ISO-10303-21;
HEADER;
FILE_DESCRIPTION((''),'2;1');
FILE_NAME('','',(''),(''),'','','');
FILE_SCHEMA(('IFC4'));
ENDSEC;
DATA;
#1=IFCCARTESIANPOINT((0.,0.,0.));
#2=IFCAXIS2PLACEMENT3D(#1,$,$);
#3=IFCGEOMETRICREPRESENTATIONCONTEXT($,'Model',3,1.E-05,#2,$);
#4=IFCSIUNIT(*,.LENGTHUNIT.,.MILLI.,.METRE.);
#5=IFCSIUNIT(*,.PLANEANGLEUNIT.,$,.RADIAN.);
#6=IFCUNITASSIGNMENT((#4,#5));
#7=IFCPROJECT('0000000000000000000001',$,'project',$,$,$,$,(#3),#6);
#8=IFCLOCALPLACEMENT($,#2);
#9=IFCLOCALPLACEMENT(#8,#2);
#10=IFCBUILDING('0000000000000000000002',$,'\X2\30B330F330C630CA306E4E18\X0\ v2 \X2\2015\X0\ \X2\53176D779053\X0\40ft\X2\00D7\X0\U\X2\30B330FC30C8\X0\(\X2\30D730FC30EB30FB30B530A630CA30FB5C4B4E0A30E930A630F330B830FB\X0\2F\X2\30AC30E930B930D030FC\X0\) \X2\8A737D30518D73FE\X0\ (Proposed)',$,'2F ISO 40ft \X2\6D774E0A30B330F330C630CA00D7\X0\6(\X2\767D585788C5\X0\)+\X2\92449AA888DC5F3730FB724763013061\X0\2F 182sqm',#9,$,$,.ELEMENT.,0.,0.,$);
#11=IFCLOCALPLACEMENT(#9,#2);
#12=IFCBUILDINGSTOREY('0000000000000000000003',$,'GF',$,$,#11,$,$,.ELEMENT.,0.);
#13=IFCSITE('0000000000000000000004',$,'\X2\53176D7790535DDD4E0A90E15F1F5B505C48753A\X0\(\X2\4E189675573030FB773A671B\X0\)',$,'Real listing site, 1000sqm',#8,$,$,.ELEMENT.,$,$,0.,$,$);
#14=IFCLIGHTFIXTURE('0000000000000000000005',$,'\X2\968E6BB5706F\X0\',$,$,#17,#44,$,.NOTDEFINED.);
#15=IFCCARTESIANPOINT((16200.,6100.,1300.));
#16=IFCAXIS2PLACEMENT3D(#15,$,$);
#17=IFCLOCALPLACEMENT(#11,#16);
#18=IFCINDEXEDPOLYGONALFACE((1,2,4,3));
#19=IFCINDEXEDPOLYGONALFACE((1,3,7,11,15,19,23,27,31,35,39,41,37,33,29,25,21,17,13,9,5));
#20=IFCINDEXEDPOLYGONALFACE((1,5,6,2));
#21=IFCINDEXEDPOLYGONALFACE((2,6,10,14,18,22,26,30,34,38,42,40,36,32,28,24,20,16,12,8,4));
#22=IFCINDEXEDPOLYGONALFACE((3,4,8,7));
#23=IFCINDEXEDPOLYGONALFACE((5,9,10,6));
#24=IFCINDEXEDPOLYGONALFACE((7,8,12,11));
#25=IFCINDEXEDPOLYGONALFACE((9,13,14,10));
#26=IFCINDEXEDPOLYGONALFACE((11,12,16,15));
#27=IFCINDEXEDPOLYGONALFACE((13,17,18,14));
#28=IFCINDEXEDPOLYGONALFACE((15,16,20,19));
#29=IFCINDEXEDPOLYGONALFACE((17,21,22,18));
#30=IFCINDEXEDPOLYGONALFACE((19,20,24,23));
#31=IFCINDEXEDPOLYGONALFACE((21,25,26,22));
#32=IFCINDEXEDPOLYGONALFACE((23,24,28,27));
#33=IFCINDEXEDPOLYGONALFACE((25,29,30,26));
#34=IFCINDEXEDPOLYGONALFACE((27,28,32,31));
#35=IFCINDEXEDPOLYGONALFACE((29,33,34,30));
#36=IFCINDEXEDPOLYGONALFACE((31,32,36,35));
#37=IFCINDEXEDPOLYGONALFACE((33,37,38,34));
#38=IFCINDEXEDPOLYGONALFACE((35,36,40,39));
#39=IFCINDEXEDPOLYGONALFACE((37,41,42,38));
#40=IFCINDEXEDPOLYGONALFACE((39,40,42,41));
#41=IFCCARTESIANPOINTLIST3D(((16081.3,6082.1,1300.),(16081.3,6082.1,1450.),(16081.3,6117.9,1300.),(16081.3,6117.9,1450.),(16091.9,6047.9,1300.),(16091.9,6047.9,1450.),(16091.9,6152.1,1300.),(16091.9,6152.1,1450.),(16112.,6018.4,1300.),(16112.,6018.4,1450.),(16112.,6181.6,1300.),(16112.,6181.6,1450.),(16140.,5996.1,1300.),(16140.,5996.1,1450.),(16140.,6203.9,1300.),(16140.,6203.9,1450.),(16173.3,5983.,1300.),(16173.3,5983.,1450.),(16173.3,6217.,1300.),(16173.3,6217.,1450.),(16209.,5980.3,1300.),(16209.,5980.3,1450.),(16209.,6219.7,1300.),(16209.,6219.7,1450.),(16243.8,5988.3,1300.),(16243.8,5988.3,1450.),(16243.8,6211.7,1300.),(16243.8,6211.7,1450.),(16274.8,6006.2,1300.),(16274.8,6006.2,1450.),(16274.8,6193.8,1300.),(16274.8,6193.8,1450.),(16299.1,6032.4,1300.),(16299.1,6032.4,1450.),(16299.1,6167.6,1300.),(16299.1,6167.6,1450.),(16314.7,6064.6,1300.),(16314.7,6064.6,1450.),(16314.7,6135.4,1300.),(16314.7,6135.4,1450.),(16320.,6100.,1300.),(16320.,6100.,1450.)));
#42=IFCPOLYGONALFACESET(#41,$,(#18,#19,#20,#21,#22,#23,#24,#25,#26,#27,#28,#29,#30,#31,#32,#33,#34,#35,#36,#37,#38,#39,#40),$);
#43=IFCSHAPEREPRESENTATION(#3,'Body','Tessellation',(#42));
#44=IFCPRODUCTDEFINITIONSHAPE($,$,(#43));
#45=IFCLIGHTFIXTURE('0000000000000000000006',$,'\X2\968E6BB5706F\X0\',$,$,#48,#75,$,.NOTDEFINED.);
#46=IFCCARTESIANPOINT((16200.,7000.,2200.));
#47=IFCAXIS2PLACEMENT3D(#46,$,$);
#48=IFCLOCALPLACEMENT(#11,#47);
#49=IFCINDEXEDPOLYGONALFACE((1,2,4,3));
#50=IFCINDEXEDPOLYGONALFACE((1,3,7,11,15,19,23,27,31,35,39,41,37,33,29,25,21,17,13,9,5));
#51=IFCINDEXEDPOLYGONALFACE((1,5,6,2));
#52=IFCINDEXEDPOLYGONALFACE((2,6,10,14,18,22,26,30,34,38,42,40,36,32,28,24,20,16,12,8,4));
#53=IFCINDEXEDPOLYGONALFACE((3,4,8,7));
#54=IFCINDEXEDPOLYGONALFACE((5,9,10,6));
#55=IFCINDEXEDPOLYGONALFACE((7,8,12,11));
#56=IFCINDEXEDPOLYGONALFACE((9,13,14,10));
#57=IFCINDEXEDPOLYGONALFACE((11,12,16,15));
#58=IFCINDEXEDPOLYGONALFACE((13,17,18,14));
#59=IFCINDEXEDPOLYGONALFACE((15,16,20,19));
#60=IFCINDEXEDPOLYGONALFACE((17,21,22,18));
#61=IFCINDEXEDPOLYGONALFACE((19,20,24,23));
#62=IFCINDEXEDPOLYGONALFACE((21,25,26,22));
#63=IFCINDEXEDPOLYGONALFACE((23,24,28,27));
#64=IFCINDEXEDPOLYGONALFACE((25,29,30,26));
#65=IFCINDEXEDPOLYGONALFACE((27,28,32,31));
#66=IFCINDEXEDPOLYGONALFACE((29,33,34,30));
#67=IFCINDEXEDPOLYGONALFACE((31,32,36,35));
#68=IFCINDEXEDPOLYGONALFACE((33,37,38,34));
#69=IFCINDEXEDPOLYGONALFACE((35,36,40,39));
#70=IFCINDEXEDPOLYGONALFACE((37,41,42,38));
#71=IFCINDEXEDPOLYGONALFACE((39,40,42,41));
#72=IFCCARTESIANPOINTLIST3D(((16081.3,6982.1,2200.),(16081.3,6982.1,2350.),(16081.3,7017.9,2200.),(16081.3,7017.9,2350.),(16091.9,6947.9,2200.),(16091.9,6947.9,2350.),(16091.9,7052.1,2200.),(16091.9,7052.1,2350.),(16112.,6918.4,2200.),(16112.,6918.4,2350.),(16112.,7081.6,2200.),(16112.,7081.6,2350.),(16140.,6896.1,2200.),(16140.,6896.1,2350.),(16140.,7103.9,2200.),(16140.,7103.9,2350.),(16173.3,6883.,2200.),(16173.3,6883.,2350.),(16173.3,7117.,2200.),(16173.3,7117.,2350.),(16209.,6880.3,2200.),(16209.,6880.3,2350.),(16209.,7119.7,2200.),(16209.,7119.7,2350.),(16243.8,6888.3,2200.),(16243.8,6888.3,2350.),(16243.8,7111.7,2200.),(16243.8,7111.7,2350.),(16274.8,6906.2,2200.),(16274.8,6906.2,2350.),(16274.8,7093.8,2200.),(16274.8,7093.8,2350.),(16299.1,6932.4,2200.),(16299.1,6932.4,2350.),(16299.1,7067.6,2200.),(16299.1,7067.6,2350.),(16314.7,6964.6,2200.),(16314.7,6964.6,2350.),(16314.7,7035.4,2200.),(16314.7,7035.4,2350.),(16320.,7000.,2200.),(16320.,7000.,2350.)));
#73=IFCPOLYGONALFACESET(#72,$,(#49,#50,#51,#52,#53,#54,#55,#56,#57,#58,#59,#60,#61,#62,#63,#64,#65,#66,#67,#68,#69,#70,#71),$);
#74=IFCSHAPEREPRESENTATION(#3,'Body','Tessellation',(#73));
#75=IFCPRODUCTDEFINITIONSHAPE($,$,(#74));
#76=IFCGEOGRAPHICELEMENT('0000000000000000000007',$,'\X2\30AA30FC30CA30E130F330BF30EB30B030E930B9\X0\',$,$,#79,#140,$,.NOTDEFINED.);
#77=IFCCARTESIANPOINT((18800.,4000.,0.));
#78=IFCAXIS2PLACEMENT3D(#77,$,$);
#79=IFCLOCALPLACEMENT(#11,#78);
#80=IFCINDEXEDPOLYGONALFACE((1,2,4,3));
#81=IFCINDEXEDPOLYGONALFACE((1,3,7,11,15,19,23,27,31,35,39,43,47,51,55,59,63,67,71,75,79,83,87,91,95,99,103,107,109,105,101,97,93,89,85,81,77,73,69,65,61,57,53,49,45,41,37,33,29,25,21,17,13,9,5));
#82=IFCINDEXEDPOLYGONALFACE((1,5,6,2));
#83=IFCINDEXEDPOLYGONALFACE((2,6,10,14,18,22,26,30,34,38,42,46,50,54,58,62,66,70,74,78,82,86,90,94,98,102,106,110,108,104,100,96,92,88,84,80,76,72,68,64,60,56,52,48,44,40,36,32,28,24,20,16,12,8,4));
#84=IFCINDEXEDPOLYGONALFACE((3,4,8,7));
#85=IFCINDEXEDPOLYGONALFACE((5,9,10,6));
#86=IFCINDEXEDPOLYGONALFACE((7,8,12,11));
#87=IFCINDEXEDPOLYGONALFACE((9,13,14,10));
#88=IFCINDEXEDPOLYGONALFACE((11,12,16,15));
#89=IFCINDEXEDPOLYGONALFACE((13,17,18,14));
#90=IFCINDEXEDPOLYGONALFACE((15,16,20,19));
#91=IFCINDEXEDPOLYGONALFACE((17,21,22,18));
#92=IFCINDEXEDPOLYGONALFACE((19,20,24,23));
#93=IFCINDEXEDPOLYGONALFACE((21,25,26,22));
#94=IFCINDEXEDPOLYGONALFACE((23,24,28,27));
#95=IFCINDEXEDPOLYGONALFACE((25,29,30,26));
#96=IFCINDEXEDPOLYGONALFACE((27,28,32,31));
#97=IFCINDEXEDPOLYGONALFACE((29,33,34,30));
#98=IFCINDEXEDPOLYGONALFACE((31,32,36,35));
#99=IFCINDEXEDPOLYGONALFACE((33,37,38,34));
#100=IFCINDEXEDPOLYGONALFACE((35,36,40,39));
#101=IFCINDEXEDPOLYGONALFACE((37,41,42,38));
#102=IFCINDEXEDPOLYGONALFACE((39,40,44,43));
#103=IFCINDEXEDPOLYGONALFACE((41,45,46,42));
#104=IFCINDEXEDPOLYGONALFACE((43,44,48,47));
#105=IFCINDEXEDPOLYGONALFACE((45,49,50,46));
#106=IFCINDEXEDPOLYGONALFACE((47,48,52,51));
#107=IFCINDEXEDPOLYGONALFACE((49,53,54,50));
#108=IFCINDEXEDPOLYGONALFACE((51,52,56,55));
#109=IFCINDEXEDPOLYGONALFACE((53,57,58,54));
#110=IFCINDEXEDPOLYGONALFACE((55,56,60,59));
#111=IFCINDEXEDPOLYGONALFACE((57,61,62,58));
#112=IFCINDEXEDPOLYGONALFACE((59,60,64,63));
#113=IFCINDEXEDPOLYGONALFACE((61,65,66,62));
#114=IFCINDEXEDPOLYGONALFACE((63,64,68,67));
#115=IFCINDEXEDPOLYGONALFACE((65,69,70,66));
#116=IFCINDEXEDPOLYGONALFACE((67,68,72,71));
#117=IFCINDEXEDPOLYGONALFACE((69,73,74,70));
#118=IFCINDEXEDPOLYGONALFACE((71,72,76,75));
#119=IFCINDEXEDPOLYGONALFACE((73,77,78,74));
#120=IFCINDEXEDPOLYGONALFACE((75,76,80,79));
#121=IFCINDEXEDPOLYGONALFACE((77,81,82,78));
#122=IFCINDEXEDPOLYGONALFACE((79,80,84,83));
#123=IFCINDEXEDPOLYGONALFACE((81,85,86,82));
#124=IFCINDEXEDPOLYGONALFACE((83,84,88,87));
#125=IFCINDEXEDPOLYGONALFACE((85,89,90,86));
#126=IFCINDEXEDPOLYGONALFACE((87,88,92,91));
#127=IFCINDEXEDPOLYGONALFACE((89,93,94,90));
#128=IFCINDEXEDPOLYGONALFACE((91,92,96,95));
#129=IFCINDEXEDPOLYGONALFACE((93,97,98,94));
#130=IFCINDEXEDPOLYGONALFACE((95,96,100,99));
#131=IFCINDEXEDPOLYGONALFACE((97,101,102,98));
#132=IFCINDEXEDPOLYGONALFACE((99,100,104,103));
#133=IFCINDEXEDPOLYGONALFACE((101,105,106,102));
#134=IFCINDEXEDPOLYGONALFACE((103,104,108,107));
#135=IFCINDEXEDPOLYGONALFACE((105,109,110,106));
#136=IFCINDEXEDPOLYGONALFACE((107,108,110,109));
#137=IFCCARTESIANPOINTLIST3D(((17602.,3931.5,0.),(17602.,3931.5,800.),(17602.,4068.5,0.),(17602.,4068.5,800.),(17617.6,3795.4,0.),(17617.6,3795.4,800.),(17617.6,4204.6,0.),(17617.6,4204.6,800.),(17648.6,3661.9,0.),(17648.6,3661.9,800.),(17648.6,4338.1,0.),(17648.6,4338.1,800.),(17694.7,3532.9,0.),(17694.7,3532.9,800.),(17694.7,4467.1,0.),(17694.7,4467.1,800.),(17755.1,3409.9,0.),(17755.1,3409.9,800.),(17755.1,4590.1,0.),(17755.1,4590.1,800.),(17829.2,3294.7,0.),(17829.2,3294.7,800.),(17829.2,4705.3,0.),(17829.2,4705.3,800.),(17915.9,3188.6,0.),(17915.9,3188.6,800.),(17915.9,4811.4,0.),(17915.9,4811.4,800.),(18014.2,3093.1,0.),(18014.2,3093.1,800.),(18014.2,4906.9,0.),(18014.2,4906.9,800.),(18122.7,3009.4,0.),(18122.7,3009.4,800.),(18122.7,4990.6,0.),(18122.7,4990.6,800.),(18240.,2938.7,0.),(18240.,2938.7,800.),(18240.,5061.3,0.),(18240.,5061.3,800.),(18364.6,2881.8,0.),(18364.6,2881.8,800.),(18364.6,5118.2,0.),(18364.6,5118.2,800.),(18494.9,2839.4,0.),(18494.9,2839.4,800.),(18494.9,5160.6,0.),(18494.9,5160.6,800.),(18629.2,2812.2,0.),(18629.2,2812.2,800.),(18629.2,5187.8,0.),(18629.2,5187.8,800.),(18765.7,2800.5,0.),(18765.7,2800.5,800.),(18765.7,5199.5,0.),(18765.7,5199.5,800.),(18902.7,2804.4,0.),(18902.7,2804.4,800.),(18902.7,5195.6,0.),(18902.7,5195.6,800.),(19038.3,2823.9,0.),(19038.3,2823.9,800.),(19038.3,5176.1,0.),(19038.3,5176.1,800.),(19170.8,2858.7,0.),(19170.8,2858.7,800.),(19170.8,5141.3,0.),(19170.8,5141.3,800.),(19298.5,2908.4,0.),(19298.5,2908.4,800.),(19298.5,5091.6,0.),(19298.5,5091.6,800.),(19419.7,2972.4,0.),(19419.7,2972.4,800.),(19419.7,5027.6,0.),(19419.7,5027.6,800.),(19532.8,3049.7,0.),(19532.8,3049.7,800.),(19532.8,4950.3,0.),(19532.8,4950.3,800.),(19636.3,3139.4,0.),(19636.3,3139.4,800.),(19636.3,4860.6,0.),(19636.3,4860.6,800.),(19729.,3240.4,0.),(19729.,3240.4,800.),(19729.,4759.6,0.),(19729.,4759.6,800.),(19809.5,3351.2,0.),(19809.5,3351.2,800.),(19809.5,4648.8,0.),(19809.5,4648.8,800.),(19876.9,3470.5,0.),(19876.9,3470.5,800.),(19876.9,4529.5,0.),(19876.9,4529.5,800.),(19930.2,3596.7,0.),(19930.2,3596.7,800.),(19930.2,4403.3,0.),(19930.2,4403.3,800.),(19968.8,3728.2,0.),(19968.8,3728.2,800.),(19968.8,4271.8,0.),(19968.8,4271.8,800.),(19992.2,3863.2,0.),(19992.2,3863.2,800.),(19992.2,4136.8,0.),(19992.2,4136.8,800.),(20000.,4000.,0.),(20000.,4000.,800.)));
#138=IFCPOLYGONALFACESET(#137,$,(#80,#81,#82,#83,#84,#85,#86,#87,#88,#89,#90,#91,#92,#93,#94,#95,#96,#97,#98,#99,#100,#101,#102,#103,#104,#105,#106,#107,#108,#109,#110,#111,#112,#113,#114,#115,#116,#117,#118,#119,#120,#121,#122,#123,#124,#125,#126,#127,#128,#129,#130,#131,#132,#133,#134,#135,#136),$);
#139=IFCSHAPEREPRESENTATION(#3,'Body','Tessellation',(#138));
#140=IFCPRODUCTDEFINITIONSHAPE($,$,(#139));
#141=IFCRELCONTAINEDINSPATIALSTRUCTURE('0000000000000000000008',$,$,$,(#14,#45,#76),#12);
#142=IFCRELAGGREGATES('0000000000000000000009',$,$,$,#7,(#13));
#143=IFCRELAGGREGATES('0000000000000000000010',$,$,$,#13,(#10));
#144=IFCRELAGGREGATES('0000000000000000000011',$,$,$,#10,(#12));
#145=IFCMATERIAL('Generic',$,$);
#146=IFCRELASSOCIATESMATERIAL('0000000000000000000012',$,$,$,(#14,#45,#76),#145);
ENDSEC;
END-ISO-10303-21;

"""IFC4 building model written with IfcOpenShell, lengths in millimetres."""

from ifc_helpers import new_model, si_unit, frame, origin, origin_2d, place, context, project, spatial, circle, extrude, material, element, save


model = new_model("IFC4")

# Units and contexts
model_context = context("Model", 3, precision=1e-05, world=origin())
ifc_project = project(units=[si_unit("LENGTHUNIT", "METRE", prefix="MILLI"), si_unit("PLANEANGLEUNIT", "RADIAN")], contexts=[model_context])

# Site, building, storey
site_placement = place(None, origin())
site = spatial("IfcSite", under=ifc_project, at=site_placement, Name="北海道川上郡弟子屈町(丘陵地・眺望)", ObjectType="Real listing site, 1000sqm", CompositionType="ELEMENT", RefElevation=0.0)
building_placement = place(site_placement, origin())
building = spatial("IfcBuilding", under=site, at=building_placement, Name="コンテナの丘 v2 ― 北海道40ft×Uコート(プール・サウナ・屋上ラウンジ・2Fガラスバー) 詳細再現 (Proposed)", ObjectType="2F ISO 40ft 海上コンテナ×6(白塗装)+鉄骨補強・片持ち2F 182sqm", CompositionType="ELEMENT", ElevationOfRefHeight=0.0, ElevationOfTerrain=0.0)
storey_placement = place(building_placement, origin())
storey = spatial("IfcBuildingStorey", under=building, at=storey_placement, Name="GF", CompositionType="ELEMENT", Elevation=0.0)

# Shared definitions
ifc_material = material(Name="Generic")

# Light fixtures
light_fixture_1_placement = place(storey_placement, frame((16200.0, 6100.0, 1300.0)))
element("IfcLightFixture", 1, at=light_fixture_1_placement, inside=storey, material=ifc_material, Name="階段灯", PredefinedType="NOTDEFINED", context=model_context, shape_type="SweptSolid", body=[
    extrude(circle(Radius=120.0, at=origin_2d()), frame((16200.0, 6100.0, 1300.0)), (0.0, 0.0, 1.0), 150.0),
])
light_fixture_2_placement = place(storey_placement, frame((16200.0, 7000.0, 2200.0)))
element("IfcLightFixture", 2, at=light_fixture_2_placement, inside=storey, material=ifc_material, Name="階段灯", PredefinedType="NOTDEFINED", context=model_context, shape_type="SweptSolid", body=[
    extrude(circle(Radius=120.0, at=origin_2d()), frame((16200.0, 7000.0, 2200.0)), (0.0, 0.0, 1.0), 150.0),
])

# Geographic element
geographic_element_1_placement = place(storey_placement, frame((18800.0, 4000.0, 0.0)))
element("IfcGeographicElement", 3, at=geographic_element_1_placement, inside=storey, material=ifc_material, Name="オーナメンタルグラス", PredefinedType="NOTDEFINED", context=model_context, shape_type="SweptSolid", body=[
    extrude(circle(Radius=1200.0, at=origin_2d()), frame((18800.0, 4000.0, 0.0)), (0.0, 0.0, 1.0), 800.0),
])

save(model, "model.ifc")
